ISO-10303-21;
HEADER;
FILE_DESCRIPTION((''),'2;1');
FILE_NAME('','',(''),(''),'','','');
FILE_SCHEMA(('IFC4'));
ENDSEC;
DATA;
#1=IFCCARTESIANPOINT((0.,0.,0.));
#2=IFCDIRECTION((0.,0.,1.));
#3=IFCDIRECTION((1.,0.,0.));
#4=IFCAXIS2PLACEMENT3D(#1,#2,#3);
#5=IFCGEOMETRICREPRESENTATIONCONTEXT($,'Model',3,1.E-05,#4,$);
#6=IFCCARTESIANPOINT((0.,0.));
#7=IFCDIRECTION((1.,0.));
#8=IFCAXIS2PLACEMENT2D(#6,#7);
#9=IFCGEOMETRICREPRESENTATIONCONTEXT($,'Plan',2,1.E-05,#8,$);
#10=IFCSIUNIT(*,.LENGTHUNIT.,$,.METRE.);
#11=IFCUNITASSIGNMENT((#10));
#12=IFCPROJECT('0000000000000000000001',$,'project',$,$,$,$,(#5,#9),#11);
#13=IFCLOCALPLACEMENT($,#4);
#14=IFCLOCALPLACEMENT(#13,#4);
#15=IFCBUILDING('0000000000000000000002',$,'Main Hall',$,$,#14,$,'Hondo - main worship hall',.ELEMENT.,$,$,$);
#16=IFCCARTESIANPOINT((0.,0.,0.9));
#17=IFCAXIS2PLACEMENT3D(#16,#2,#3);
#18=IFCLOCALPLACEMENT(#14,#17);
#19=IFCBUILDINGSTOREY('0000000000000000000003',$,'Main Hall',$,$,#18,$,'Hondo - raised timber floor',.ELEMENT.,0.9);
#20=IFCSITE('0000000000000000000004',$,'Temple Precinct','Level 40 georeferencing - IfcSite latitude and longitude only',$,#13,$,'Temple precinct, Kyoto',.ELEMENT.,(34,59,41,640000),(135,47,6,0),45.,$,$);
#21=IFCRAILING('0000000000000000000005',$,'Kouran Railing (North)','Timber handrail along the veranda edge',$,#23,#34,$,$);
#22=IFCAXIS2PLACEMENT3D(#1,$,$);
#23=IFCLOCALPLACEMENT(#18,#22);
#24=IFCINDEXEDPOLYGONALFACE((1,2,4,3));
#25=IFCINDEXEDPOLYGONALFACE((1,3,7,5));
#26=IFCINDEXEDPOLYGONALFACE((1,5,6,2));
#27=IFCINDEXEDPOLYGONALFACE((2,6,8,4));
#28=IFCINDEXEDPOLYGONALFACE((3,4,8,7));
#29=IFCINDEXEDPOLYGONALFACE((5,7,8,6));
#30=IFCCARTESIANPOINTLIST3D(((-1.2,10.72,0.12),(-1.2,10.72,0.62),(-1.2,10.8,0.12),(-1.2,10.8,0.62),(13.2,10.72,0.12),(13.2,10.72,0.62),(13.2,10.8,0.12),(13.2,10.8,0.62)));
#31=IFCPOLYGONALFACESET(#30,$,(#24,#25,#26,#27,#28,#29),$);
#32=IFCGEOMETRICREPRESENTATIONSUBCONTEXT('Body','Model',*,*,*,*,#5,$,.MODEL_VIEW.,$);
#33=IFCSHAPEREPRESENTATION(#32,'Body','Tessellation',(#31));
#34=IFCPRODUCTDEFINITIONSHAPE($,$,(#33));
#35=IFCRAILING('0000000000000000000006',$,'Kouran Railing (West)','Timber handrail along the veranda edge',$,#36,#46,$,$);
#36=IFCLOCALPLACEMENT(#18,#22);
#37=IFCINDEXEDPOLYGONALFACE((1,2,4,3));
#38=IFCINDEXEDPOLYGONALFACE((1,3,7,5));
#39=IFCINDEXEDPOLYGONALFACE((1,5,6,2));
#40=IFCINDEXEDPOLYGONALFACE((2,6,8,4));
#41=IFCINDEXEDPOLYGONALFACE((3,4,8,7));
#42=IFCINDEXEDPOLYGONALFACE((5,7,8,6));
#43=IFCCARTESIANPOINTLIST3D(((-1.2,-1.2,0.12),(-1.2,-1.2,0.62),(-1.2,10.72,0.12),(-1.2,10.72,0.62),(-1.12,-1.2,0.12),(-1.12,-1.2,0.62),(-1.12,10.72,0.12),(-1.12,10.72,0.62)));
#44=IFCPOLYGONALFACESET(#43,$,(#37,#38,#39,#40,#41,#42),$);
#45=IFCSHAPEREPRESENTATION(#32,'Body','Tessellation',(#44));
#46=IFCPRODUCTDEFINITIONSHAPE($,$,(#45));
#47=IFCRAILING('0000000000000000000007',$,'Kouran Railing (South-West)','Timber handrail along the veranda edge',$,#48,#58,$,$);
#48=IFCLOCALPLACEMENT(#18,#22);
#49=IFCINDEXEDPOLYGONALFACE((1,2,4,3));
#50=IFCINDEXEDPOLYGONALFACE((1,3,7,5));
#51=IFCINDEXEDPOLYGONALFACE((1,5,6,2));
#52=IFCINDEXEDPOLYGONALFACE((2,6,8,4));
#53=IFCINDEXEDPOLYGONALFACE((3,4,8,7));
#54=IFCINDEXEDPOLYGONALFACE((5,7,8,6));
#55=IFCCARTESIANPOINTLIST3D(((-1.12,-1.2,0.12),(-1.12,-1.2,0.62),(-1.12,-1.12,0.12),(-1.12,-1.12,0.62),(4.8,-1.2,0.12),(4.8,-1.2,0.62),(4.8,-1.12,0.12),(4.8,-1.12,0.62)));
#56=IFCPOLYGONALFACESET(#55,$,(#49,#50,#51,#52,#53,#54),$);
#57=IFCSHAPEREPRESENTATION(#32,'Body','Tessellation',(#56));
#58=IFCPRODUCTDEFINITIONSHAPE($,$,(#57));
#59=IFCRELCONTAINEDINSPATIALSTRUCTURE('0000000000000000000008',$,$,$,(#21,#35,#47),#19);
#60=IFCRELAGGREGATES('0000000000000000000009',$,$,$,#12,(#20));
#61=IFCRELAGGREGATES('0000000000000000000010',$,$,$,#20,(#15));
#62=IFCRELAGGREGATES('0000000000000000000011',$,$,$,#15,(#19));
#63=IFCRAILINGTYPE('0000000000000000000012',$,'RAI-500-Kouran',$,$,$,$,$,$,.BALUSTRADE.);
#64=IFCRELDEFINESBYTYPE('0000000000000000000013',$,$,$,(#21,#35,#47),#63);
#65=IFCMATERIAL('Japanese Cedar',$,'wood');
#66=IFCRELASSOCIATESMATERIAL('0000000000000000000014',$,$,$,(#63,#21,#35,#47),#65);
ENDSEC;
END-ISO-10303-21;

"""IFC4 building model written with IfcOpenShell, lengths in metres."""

from ifc_helpers import new_model, si_unit, frame, origin_with_axes, origin_2d_with_axis, place, context, subcontext, project, spatial, line, indexed_curve, outline, extrude, material, type_object, element, save


model = new_model("IFC4")

# Units and contexts
model_context = context("Model", 3, precision=1e-05, world=origin_with_axes())
plan_context = context("Plan", 2, precision=1e-05, world=origin_2d_with_axis())
body_context = subcontext(model_context, "Body", "Model", "MODEL_VIEW")
ifc_project = project(units=[si_unit("LENGTHUNIT", "METRE")], contexts=[model_context, plan_context])

# Site, building, storey
site_placement = place(None, origin_with_axes())
site = spatial("IfcSite", under=ifc_project, at=site_placement, Name="Temple Precinct", Description="Level 40 georeferencing - IfcSite latitude and longitude only", LongName="Temple precinct, Kyoto", CompositionType="ELEMENT", RefLatitude=(34, 59, 41, 640000), RefLongitude=(135, 47, 6, 0), RefElevation=45.0)
building_placement = place(site_placement, origin_with_axes())
building = spatial("IfcBuilding", under=site, at=building_placement, Name="Main Hall", LongName="Hondo - main worship hall", CompositionType="ELEMENT")
storey_placement = place(building_placement, frame((0.0, 0.0, 0.9), z_axis=(0.0, 0.0, 1.0), x_axis=(1.0, 0.0, 0.0)))
storey = spatial("IfcBuildingStorey", under=building, at=storey_placement, Name="Main Hall", LongName="Hondo - raised timber floor", CompositionType="ELEMENT", Elevation=0.9)

# Shared definitions
ifc_material_1 = material(Name="Japanese Cedar", Category="wood")

# Railings
railing_type = type_object("IfcRailingType", Name="RAI-500-Kouran", PredefinedType="BALUSTRADE", material=ifc_material_1)
railing_1_placement = place(storey_placement, frame((-1.2, 10.72, 0.12), z_axis=(0.0, 0.0, 1.0), x_axis=(1.0, 0.0, 0.0)))
element("IfcRailing", 1, at=railing_1_placement, inside=storey, type_object=railing_type, material=ifc_material_1, Name="Kouran Railing (North)", Description="Timber handrail along the veranda edge", context=body_context, shape_type="SweptSolid", body=[
    extrude(outline(indexed_curve([(0.0, 0.0), (14.4, 0.0), (14.4, 0.08), (0.0, 0.08)], segments=[line(1, 2, 3, 4, 1)])), origin_with_axes(), (0.0, 0.0, 1.0), 0.5),
])
railing_2_placement = place(storey_placement, frame((-1.2, -1.2, 0.12), z_axis=(0.0, 0.0, 1.0), x_axis=(1.0, 0.0, 0.0)))
element("IfcRailing", 2, at=railing_2_placement, inside=storey, type_object=railing_type, material=ifc_material_1, Name="Kouran Railing (West)", Description="Timber handrail along the veranda edge", context=body_context, shape_type="SweptSolid", body=[
    extrude(outline(indexed_curve([(0.0, 0.0), (0.08, 0.0), (0.08, 11.92), (0.0, 11.92)], segments=[line(1, 2, 3, 4, 1)])), origin_with_axes(), (0.0, 0.0, 1.0), 0.5),
])
railing_3_placement = place(storey_placement, frame((-1.12, -1.2, 0.12), z_axis=(0.0, 0.0, 1.0), x_axis=(1.0, 0.0, 0.0)))
element("IfcRailing", 3, at=railing_3_placement, inside=storey, type_object=railing_type, material=ifc_material_1, Name="Kouran Railing (South-West)", Description="Timber handrail along the veranda edge", context=body_context, shape_type="SweptSolid", body=[
    extrude(outline(indexed_curve([(0.0, 0.0), (5.92, 0.0), (5.92, 0.08), (0.0, 0.08)], segments=[line(1, 2, 3, 4, 1)])), origin_with_axes(), (0.0, 0.0, 1.0), 0.5),
])

save(model, "model.ifc")
